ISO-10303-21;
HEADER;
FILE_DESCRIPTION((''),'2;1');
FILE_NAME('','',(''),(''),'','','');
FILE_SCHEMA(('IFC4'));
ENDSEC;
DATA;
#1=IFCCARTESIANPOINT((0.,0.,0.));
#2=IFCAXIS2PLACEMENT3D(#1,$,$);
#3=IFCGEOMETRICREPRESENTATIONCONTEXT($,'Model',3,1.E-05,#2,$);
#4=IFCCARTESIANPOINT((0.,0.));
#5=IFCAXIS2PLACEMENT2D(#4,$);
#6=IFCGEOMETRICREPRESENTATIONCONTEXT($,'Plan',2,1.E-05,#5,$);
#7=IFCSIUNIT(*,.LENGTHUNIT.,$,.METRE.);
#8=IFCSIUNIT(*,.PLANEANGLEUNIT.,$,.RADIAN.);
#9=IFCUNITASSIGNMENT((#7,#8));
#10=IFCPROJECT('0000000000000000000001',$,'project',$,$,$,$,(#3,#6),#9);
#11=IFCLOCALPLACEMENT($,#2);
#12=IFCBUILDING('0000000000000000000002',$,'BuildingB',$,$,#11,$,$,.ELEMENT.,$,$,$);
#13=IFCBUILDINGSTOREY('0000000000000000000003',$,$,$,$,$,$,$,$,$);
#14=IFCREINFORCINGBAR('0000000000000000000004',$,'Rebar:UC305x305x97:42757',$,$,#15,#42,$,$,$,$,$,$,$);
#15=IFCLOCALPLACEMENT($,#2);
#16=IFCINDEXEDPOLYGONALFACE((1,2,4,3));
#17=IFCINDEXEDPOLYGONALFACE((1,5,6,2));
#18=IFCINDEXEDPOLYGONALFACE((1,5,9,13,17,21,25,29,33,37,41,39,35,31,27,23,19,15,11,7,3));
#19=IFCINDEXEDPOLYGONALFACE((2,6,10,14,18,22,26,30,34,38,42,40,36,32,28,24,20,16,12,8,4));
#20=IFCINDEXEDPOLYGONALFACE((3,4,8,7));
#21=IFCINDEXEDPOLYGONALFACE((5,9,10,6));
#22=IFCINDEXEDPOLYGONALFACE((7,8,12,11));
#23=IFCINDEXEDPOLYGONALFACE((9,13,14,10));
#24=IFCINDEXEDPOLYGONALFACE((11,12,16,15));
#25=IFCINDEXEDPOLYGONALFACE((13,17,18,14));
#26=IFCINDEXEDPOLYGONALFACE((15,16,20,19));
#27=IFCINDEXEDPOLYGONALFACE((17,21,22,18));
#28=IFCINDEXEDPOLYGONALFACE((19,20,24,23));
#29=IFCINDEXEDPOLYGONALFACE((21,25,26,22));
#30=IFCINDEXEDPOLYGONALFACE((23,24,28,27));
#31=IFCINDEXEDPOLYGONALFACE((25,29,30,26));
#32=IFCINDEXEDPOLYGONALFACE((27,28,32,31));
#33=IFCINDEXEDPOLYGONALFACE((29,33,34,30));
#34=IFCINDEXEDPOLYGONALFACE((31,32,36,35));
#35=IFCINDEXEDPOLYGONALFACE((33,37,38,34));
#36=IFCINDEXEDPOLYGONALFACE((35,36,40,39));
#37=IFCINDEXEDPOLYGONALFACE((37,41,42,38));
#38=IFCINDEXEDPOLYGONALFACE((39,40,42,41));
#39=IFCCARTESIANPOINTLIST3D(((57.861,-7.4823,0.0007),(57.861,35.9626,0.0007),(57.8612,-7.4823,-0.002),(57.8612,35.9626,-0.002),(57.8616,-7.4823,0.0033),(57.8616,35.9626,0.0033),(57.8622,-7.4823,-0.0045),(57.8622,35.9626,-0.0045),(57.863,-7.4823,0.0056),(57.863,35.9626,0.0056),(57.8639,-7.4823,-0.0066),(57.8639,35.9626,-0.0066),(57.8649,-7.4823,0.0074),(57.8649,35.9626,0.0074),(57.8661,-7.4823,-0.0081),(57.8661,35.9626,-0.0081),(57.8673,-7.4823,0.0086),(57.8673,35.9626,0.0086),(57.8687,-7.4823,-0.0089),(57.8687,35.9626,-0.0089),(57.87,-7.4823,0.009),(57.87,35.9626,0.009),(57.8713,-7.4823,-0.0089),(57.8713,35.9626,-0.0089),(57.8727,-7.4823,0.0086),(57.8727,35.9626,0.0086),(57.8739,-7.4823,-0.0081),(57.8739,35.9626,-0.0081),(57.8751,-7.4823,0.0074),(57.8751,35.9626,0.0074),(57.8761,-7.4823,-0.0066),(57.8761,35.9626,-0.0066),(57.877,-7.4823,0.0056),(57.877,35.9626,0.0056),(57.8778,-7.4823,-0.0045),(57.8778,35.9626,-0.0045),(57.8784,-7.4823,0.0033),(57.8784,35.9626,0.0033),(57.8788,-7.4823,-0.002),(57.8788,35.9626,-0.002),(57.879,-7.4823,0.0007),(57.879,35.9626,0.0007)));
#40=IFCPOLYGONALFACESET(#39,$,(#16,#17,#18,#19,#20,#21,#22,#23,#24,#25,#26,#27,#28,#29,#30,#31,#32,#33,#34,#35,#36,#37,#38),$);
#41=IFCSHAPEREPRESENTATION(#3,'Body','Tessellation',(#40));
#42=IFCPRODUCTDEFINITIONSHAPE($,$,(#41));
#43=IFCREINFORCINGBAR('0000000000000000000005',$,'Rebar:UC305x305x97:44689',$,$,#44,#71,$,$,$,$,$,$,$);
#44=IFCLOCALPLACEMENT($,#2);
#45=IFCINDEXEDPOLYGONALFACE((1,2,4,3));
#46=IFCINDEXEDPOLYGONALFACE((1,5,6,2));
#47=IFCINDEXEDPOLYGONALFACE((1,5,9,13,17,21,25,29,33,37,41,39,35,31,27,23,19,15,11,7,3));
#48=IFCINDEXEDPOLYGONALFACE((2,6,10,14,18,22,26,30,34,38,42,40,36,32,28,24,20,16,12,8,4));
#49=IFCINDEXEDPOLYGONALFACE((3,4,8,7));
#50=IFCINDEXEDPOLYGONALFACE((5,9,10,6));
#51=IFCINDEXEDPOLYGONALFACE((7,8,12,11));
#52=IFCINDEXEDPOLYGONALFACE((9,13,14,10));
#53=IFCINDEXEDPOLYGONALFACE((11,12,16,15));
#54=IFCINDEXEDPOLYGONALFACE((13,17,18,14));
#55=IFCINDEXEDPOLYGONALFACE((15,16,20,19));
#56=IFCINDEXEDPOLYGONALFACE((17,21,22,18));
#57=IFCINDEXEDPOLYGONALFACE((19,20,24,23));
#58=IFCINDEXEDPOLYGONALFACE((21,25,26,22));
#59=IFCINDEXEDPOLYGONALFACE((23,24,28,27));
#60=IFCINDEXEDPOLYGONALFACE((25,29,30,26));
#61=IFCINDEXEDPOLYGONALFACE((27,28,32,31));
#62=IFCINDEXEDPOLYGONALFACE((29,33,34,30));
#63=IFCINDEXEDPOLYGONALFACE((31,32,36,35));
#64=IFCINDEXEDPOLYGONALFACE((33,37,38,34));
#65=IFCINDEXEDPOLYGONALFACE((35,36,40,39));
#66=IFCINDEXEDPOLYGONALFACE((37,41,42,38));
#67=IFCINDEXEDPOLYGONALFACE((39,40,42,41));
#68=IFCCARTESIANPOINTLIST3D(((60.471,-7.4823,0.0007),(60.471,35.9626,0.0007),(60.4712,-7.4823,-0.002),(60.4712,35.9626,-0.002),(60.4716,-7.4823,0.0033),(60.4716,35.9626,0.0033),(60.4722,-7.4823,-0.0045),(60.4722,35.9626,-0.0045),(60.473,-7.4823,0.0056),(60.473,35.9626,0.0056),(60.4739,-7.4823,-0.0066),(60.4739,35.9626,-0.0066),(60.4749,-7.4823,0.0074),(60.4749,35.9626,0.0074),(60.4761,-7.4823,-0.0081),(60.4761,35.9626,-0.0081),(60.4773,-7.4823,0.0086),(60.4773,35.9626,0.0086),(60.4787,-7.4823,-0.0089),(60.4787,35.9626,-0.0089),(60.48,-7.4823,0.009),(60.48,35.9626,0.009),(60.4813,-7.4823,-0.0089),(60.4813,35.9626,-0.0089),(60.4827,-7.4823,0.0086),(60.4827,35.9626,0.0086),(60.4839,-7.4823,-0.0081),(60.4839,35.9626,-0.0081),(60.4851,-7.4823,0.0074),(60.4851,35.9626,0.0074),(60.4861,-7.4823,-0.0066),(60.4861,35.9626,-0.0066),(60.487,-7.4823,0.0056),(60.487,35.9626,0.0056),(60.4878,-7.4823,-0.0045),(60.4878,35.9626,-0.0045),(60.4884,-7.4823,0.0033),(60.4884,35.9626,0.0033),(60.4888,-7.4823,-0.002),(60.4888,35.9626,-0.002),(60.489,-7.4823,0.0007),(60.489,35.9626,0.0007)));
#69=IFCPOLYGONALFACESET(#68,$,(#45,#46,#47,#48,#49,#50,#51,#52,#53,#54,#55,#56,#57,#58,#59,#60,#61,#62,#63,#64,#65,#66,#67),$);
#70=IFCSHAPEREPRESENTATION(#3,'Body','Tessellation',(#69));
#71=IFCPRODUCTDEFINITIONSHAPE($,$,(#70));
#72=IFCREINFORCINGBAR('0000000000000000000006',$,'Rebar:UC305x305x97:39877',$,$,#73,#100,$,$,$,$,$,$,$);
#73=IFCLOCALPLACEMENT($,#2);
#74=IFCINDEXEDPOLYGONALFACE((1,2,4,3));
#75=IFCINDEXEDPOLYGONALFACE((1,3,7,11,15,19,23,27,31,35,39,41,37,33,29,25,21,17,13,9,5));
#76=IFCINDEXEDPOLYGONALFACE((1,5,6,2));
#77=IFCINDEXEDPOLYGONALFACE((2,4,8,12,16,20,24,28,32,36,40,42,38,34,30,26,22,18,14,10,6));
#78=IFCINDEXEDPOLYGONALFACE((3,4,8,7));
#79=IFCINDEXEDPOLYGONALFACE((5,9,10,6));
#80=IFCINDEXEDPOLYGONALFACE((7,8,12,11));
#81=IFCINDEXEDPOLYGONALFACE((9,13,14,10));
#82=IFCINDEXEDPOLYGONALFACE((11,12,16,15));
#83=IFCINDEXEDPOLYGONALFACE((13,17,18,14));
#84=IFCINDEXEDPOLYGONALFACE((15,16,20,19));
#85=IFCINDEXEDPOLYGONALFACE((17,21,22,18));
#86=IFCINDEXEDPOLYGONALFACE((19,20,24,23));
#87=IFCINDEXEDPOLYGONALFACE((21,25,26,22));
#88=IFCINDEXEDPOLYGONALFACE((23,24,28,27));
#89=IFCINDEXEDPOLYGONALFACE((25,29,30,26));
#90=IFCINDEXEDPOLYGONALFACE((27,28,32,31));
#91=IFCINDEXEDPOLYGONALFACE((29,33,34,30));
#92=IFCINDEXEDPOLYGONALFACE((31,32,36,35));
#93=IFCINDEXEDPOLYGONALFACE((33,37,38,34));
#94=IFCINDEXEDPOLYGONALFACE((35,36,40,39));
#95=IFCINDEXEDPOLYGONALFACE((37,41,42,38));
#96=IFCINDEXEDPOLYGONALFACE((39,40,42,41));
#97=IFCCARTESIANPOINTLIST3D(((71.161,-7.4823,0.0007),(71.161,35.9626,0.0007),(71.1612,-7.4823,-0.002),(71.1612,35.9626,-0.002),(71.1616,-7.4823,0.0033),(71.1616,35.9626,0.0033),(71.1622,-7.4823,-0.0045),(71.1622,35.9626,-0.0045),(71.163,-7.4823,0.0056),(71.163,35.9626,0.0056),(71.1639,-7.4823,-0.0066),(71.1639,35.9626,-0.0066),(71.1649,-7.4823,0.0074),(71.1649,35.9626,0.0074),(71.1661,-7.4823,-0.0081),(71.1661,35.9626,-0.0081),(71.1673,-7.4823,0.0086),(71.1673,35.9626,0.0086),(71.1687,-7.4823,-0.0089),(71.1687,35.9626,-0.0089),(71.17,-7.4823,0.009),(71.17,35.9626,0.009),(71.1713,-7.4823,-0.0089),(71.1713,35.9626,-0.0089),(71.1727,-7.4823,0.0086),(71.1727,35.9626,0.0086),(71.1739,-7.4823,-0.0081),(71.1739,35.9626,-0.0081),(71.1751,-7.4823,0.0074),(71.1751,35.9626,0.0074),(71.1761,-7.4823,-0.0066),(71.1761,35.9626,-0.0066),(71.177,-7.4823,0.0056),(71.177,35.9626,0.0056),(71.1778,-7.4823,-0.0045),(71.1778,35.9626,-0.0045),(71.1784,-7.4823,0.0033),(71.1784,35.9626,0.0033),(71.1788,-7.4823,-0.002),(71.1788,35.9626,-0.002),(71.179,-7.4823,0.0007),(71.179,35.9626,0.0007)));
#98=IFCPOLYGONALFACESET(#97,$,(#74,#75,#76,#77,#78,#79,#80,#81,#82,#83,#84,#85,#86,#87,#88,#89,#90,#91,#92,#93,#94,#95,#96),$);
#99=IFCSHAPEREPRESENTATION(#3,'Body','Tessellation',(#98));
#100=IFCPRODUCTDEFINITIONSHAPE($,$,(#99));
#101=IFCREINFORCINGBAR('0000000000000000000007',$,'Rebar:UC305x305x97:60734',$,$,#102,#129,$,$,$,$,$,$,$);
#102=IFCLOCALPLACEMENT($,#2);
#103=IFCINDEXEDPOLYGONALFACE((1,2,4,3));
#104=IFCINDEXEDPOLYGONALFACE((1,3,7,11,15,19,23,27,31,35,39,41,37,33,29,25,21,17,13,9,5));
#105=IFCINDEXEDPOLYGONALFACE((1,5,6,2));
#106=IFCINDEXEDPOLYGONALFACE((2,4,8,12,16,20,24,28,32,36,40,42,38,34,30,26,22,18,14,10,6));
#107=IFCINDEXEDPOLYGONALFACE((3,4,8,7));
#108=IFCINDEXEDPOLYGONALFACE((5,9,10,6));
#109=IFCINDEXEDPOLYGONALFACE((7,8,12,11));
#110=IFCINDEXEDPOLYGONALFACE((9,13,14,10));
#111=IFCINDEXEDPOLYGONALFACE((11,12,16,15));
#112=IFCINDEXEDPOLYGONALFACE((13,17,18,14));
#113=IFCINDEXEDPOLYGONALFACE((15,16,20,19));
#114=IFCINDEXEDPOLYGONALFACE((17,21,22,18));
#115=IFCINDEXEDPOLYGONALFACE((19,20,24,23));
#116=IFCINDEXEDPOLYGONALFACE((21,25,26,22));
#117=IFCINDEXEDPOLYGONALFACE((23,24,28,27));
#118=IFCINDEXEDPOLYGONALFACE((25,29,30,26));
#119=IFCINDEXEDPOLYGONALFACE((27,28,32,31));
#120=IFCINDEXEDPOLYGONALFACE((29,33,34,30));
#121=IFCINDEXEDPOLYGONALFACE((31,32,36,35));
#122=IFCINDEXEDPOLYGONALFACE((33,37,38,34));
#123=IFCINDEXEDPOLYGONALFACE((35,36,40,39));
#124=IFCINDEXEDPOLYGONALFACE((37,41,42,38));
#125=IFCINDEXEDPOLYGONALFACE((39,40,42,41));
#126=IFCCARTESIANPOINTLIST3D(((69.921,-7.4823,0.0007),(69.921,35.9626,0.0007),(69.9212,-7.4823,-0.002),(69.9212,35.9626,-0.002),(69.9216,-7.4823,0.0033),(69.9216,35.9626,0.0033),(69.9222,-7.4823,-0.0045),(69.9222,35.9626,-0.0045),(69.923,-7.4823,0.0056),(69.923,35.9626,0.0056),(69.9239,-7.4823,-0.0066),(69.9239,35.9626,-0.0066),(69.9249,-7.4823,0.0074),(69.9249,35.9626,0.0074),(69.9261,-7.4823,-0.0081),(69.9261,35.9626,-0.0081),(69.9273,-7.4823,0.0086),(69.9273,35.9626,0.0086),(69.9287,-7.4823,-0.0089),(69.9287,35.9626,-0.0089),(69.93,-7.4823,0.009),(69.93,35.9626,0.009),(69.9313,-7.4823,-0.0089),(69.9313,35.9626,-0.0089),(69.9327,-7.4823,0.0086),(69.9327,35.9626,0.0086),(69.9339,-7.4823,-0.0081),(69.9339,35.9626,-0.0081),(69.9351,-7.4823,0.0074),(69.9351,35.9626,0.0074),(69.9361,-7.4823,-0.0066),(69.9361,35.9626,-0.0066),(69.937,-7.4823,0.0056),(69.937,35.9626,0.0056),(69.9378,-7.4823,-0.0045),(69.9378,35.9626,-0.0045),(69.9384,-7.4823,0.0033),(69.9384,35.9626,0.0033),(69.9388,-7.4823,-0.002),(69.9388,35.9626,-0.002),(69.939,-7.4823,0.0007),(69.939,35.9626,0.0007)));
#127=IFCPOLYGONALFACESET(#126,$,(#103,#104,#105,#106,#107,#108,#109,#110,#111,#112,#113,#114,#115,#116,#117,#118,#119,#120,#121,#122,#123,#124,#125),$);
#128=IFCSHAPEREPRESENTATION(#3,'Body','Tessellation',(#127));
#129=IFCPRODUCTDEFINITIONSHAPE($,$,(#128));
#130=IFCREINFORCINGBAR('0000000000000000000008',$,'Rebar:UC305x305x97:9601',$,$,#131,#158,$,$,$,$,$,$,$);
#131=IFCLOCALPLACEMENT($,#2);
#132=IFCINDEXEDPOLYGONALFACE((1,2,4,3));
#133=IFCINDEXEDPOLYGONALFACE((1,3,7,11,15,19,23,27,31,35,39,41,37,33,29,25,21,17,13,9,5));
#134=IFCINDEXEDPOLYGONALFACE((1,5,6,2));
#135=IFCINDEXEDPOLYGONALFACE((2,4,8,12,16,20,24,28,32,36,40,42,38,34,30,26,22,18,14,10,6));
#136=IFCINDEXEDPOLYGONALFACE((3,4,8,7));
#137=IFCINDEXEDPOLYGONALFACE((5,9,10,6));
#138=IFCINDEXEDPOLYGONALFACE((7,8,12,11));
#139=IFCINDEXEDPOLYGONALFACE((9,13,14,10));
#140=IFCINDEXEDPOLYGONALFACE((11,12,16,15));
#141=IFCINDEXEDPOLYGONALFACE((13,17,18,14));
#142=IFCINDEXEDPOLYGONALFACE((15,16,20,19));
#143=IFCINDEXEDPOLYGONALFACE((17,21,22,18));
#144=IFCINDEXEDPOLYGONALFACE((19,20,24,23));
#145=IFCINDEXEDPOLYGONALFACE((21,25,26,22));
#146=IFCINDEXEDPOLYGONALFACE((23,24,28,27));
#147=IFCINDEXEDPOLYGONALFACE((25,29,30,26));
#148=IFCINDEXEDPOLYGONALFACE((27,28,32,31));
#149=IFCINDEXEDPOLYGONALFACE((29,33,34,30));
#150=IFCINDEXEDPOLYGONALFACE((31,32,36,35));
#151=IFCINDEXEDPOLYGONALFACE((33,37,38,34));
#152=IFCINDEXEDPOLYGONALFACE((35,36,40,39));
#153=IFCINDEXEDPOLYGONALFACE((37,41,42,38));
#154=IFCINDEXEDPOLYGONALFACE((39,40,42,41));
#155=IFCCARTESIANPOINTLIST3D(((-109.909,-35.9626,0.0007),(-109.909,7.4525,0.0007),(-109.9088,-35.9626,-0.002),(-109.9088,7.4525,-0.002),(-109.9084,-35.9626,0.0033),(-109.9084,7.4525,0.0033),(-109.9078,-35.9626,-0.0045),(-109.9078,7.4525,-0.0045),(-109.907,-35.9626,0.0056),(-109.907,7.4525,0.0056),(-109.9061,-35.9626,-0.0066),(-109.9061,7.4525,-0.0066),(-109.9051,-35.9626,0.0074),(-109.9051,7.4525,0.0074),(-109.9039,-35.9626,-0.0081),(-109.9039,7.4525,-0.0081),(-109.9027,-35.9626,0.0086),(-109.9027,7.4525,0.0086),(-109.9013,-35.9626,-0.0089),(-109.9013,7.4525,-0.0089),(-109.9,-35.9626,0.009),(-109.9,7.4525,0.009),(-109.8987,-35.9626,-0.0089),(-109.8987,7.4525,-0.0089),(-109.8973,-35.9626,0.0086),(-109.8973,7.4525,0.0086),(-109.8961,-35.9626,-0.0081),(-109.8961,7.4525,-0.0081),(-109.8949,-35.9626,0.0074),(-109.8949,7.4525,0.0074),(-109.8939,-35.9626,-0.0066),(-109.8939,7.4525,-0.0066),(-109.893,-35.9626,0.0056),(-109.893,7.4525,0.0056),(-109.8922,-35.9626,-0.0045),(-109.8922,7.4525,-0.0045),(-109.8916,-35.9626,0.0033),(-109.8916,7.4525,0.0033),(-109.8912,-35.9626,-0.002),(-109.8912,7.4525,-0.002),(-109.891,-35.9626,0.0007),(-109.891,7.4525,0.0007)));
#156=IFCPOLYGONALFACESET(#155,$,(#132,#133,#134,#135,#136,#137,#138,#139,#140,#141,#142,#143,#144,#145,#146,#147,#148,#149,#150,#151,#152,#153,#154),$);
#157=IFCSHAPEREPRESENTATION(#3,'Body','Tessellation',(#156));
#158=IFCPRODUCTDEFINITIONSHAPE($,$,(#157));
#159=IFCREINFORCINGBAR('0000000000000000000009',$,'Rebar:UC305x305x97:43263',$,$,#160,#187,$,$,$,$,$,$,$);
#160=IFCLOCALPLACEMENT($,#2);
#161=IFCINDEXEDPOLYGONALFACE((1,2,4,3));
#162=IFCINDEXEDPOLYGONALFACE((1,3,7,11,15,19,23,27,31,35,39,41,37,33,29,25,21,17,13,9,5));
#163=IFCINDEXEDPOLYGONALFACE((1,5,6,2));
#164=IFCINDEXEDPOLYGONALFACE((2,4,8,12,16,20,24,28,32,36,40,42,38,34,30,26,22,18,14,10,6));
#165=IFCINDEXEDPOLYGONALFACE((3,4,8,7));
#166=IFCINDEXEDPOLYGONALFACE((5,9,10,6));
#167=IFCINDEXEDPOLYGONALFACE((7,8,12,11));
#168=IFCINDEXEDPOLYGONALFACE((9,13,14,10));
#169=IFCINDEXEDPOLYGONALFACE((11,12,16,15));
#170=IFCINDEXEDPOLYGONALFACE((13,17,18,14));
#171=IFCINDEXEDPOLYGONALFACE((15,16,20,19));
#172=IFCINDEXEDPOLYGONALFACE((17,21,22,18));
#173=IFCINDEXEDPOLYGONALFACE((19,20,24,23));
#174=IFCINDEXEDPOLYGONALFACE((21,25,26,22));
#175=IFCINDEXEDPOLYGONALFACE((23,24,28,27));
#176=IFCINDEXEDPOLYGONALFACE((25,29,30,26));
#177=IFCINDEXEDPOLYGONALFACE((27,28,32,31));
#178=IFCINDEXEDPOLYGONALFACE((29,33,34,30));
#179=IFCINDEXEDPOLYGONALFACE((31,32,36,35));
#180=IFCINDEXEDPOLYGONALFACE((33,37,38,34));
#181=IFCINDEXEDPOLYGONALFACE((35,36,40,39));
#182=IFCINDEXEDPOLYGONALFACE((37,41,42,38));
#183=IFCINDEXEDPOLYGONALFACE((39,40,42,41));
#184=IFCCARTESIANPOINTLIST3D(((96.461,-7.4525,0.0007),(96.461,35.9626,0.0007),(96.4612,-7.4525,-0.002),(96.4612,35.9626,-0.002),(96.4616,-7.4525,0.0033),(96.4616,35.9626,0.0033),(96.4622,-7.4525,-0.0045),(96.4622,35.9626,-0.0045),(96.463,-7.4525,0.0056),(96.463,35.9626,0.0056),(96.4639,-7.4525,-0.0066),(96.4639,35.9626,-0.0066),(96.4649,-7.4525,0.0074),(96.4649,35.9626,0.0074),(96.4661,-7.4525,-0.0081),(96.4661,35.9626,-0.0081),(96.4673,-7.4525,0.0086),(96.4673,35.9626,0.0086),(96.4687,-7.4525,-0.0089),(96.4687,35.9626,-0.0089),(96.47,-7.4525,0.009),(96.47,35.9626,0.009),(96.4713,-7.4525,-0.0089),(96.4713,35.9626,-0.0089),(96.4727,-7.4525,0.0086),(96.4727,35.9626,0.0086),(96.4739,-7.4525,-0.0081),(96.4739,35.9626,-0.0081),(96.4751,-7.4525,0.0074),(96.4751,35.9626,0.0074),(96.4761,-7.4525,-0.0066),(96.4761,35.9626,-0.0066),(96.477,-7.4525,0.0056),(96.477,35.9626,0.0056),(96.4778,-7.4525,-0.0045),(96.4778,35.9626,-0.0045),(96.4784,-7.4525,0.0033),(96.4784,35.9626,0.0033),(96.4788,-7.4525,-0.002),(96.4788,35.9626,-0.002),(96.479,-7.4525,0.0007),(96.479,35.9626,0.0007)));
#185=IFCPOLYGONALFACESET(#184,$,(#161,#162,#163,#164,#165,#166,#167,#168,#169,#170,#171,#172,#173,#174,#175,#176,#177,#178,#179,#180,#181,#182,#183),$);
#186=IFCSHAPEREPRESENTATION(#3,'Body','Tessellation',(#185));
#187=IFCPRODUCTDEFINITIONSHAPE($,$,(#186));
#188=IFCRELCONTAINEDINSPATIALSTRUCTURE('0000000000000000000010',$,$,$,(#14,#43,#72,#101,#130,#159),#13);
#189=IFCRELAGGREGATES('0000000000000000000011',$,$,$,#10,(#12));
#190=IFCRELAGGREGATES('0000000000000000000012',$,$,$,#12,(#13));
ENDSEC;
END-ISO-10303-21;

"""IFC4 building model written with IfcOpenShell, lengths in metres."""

from ifc_helpers import new_model, entity, si_unit, origin, origin_2d, place, context, project, spatial, element, save


model = new_model("IFC4")

# Units and contexts
model_context = context("Model", 3, precision=1e-05, world=origin())
plan_context = context("Plan", 2, precision=1e-05, world=origin_2d())
ifc_project = project(units=[si_unit("LENGTHUNIT", "METRE"), si_unit("PLANEANGLEUNIT", "RADIAN")], contexts=[model_context, plan_context])

# Building, storey
building_placement = place(None, origin())
building = spatial("IfcBuilding", under=ifc_project, at=building_placement, Name="BuildingB", CompositionType="ELEMENT")
storey = spatial("IfcBuildingStorey", under=building)

# Reinforcing bars
element("IfcReinforcingBar", 1, inside=storey, Name="Rebar:UC305x305x97:42757", context=model_context, shape_type="SweptSolid", body=[
    entity("IfcSurfaceCurveSweptAreaSolid", entity("IfcCircleProfileDef", "AREA", None, None, 0.009), None, entity("IfcPolyline", [entity("IfcCartesianPoint", [57.87, -7.4823, 0.0]), entity("IfcCartesianPoint", [57.87, 35.9626, 0.0])]), None, None, entity("IfcPlane", entity("IfcAxis2Placement3D", entity("IfcCartesianPoint", [57.87, -7.4823, 0.0]), entity("IfcDirection", [0.0, 0.0, 1.0]), entity("IfcDirection", [1.0, 0.0, 0.0])))),
])
element("IfcReinforcingBar", 2, inside=storey, Name="Rebar:UC305x305x97:44689", context=model_context, shape_type="SweptSolid", body=[
    entity("IfcSurfaceCurveSweptAreaSolid", entity("IfcCircleProfileDef", "AREA", None, None, 0.009), None, entity("IfcPolyline", [entity("IfcCartesianPoint", [60.48, -7.4823, 0.0]), entity("IfcCartesianPoint", [60.48, 35.9626, 0.0])]), None, None, entity("IfcPlane", entity("IfcAxis2Placement3D", entity("IfcCartesianPoint", [60.48, -7.4823, 0.0]), entity("IfcDirection", [0.0, 0.0, 1.0]), entity("IfcDirection", [1.0, 0.0, 0.0])))),
])
element("IfcReinforcingBar", 3, inside=storey, Name="Rebar:UC305x305x97:39877", context=model_context, shape_type="SweptSolid", body=[
    entity("IfcSurfaceCurveSweptAreaSolid", entity("IfcCircleProfileDef", "AREA", None, None, 0.009), None, entity("IfcPolyline", [entity("IfcCartesianPoint", [71.17, 35.9626, 0.0]), entity("IfcCartesianPoint", [71.17, -7.4823, 0.0])]), None, None, entity("IfcPlane", entity("IfcAxis2Placement3D", entity("IfcCartesianPoint", [71.17, 35.9626, 0.0]), entity("IfcDirection", [0.0, 0.0, 1.0]), entity("IfcDirection", [1.0, 0.0, 0.0])))),
])
element("IfcReinforcingBar", 4, inside=storey, Name="Rebar:UC305x305x97:60734", context=model_context, shape_type="SweptSolid", body=[
    entity("IfcSurfaceCurveSweptAreaSolid", entity("IfcCircleProfileDef", "AREA", None, None, 0.009), None, entity("IfcPolyline", [entity("IfcCartesianPoint", [69.93, 35.9626, 0.0]), entity("IfcCartesianPoint", [69.93, -7.4823, 0.0])]), None, None, entity("IfcPlane", entity("IfcAxis2Placement3D", entity("IfcCartesianPoint", [69.93, 35.9626, 0.0]), entity("IfcDirection", [0.0, 0.0, 1.0]), entity("IfcDirection", [1.0, 0.0, 0.0])))),
])
element("IfcReinforcingBar", 5, inside=storey, Name="Rebar:UC305x305x97:9601", context=model_context, shape_type="SweptSolid", body=[
    entity("IfcSurfaceCurveSweptAreaSolid", entity("IfcCircleProfileDef", "AREA", None, None, 0.009), None, entity("IfcPolyline", [entity("IfcCartesianPoint", [109.9, 35.9626, 0.0]), entity("IfcCartesianPoint", [109.9, -7.4525, 0.0])]), None, None, entity("IfcPlane", entity("IfcAxis2Placement3D", entity("IfcCartesianPoint", [109.9, 35.9626, 0.0]), entity("IfcDirection", [0.0, 0.0, 1.0]), entity("IfcDirection", [1.0, 0.0, 0.0])))),
])
element("IfcReinforcingBar", 6, inside=storey, Name="Rebar:UC305x305x97:43263", context=model_context, shape_type="SweptSolid", body=[
    entity("IfcSurfaceCurveSweptAreaSolid", entity("IfcCircleProfileDef", "AREA", None, None, 0.009), None, entity("IfcPolyline", [entity("IfcCartesianPoint", [96.47, 35.9626, 0.0]), entity("IfcCartesianPoint", [96.47, -7.4525, 0.0])]), None, None, entity("IfcPlane", entity("IfcAxis2Placement3D", entity("IfcCartesianPoint", [96.47, 35.9626, 0.0]), entity("IfcDirection", [0.0, 0.0, 1.0]), entity("IfcDirection", [1.0, 0.0, 0.0])))),
])

save(model, "model.ifc")
